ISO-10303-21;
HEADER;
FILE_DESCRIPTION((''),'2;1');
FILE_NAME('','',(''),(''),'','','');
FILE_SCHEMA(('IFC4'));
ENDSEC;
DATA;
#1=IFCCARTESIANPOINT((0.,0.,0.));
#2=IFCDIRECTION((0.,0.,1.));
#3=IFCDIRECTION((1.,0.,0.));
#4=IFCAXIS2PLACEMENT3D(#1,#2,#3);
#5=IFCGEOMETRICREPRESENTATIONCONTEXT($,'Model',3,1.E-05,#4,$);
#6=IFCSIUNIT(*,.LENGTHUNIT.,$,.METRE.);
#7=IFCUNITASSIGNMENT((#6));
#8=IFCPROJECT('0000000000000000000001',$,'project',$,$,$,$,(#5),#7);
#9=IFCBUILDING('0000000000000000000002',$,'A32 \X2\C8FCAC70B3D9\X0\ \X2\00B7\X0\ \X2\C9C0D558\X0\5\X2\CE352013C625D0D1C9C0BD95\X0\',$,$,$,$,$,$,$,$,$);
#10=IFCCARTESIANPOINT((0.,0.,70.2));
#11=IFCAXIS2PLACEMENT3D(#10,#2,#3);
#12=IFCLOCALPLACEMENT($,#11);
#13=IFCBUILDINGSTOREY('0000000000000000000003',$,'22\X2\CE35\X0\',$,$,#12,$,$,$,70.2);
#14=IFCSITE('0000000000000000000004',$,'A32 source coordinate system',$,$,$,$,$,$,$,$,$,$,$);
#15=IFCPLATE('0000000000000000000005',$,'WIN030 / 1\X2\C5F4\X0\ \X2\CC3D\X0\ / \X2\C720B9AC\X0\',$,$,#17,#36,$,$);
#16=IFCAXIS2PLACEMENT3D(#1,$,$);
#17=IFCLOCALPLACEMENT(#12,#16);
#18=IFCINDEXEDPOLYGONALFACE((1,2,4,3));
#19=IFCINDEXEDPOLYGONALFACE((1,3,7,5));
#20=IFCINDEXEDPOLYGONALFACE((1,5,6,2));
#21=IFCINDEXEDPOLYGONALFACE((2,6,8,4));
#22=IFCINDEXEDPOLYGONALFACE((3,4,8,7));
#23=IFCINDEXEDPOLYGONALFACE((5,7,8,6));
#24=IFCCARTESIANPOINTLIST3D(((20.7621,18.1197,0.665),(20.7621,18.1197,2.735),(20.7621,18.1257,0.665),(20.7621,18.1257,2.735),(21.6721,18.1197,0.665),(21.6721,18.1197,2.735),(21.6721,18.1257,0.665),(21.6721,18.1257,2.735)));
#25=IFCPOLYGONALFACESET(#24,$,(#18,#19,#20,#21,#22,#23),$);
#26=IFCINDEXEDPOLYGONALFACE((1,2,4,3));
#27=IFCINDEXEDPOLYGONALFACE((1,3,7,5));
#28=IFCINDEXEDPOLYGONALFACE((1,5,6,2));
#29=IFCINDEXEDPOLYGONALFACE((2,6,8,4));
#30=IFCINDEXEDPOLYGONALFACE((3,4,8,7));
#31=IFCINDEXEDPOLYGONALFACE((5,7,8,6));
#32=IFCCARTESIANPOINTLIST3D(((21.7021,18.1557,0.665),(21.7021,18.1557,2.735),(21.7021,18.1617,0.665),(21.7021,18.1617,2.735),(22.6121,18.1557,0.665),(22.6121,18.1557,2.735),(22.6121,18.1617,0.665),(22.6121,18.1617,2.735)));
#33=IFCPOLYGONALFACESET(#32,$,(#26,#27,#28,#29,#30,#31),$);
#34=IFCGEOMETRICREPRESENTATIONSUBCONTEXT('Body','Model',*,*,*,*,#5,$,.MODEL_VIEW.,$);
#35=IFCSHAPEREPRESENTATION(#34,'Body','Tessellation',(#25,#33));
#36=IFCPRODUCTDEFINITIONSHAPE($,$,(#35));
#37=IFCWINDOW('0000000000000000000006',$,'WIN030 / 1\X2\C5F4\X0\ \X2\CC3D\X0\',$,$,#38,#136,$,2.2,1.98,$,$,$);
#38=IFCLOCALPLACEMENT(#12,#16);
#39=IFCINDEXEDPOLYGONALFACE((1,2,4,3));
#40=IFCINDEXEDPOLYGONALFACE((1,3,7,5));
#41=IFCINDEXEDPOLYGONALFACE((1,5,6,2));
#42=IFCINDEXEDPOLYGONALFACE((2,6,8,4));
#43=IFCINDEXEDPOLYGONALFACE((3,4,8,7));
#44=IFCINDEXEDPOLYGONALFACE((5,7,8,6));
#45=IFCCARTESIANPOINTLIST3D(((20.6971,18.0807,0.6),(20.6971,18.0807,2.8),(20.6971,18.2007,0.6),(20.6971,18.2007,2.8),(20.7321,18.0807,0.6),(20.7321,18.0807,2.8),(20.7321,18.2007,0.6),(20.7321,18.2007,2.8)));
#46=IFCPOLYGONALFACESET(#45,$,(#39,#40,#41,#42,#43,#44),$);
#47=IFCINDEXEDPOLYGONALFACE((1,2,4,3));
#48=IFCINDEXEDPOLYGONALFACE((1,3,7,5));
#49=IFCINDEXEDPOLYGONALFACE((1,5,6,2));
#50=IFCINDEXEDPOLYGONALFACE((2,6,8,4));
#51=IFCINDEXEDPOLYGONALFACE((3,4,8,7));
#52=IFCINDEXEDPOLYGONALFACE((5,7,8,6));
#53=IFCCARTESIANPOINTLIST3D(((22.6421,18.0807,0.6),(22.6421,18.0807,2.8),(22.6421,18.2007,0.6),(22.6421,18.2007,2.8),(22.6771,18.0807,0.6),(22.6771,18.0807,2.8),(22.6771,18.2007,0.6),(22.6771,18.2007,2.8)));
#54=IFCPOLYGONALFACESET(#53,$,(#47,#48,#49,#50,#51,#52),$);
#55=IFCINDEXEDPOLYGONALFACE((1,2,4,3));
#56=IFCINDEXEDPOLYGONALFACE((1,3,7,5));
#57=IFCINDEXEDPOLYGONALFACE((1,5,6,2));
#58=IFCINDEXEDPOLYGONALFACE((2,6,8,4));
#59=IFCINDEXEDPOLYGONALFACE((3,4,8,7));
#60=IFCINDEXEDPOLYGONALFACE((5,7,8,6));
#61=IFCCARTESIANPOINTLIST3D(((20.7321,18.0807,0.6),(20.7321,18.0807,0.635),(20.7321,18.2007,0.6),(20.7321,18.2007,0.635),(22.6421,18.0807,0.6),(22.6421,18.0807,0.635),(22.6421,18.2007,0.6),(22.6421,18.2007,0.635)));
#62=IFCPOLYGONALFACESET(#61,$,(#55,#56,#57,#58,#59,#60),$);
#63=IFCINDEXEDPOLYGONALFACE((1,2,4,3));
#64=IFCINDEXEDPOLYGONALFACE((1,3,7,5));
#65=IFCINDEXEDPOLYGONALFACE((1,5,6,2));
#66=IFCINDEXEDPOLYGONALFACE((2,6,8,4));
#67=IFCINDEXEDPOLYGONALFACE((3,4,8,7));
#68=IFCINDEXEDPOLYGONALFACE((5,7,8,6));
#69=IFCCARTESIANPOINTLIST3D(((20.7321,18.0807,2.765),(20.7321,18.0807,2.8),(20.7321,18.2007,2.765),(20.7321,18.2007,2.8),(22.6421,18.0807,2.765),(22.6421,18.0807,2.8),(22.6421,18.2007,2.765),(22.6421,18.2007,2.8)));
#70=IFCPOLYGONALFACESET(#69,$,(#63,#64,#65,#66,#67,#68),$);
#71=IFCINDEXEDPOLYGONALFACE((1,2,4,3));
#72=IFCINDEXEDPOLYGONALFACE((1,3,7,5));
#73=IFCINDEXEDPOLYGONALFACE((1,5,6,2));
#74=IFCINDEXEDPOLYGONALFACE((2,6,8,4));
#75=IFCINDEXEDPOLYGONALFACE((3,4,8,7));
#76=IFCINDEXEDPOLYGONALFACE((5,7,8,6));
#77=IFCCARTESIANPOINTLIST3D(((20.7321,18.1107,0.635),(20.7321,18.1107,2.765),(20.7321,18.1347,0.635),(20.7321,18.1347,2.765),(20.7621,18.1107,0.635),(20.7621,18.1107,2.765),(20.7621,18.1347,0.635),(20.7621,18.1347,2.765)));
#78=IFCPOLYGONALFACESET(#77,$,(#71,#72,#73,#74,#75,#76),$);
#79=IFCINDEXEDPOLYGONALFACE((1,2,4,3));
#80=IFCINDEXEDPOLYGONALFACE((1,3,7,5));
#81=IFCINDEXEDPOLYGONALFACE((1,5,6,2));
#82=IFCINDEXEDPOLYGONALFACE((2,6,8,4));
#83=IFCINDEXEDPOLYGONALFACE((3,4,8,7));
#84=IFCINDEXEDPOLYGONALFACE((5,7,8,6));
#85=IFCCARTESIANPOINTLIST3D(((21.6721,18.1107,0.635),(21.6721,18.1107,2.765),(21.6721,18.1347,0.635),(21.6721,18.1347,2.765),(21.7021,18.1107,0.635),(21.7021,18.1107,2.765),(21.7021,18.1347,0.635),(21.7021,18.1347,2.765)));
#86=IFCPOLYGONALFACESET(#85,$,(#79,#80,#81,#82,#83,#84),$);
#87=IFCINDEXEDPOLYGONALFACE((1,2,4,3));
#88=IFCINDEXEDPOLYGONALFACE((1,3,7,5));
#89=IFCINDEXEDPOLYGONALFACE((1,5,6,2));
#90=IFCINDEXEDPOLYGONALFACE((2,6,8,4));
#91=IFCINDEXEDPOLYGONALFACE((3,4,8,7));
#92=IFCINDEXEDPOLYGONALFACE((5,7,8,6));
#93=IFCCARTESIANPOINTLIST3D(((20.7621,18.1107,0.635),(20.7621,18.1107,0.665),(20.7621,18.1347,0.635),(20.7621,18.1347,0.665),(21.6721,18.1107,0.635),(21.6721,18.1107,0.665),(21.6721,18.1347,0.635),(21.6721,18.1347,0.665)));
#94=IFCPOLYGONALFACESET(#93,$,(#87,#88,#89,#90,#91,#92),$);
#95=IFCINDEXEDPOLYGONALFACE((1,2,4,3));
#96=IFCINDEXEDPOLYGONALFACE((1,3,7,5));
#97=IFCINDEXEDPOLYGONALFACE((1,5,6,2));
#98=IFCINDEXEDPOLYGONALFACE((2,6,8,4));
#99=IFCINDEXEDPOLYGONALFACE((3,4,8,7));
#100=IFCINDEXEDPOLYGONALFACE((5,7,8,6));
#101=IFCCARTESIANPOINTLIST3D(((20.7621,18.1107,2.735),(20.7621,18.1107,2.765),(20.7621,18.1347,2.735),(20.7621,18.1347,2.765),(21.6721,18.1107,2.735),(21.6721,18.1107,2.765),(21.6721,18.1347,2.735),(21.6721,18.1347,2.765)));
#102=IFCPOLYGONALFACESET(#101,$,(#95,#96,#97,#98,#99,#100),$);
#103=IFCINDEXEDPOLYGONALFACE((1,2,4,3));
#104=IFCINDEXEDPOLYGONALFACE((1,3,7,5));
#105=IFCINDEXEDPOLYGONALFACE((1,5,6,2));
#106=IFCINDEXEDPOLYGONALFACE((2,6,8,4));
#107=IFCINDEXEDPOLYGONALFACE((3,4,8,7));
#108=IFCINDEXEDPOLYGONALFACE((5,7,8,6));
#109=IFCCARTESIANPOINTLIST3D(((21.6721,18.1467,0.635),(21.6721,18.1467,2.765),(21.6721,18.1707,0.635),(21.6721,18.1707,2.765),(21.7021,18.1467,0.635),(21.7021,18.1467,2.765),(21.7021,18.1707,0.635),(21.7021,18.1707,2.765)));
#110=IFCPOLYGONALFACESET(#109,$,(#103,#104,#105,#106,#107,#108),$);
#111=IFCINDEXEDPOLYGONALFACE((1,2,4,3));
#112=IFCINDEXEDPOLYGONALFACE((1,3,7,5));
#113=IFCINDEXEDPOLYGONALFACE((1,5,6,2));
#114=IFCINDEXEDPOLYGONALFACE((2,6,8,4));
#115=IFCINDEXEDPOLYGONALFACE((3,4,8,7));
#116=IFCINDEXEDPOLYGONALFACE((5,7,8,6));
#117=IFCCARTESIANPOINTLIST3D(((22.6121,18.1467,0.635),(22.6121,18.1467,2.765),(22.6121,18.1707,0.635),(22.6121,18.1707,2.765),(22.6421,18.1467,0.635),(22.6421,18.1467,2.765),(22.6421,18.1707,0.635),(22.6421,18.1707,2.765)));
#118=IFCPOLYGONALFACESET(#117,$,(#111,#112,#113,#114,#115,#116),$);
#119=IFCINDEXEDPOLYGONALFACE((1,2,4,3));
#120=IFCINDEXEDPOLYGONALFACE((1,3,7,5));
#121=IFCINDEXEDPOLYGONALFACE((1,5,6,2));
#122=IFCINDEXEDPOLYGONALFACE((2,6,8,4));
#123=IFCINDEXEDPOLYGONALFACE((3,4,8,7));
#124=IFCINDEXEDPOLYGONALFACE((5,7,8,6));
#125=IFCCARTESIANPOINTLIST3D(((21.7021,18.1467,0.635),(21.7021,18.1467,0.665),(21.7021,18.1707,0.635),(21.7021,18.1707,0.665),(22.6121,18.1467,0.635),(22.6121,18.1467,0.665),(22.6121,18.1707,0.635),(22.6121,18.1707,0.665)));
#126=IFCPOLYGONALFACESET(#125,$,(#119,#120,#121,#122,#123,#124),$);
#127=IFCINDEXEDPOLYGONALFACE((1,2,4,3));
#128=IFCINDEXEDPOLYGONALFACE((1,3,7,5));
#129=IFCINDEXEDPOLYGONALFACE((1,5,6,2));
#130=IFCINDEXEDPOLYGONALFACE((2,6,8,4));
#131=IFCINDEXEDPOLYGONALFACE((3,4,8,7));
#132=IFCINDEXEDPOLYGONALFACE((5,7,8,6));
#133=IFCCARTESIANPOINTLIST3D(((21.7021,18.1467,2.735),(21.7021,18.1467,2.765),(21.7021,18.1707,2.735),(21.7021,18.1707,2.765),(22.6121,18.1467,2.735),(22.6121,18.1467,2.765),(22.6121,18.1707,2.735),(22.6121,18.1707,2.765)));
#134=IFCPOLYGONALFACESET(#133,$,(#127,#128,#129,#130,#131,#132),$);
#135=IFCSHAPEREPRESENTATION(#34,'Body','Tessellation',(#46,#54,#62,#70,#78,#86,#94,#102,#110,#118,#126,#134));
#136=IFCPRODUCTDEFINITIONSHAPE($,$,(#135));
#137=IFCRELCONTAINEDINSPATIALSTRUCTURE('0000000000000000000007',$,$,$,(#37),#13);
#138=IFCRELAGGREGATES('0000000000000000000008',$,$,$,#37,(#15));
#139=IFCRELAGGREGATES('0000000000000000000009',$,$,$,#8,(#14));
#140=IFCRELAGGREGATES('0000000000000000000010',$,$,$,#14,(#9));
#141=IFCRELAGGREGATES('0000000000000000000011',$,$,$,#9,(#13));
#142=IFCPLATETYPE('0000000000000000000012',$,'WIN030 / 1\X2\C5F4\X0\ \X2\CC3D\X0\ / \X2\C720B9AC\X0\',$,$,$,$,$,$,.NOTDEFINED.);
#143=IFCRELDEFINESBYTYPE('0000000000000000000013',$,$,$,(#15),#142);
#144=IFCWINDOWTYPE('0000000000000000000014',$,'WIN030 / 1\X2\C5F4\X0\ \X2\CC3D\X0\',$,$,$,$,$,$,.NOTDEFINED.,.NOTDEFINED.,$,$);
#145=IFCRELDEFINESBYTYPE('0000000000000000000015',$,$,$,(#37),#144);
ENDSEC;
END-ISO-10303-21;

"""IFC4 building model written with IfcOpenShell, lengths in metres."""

from ifc_helpers import new_model, si_unit, frame, origin, origin_with_axes, place, context, subcontext, project, spatial, polyline, outline, extrude, source, transform, mapped, type_object, type_shapes, element, aggregate, save


model = new_model("IFC4")

# Units and contexts
model_context = context("Model", 3, precision=1e-05, world=origin_with_axes())
body_context = subcontext(model_context, "Body", "Model", "MODEL_VIEW")
ifc_project = project(units=[si_unit("LENGTHUNIT", "METRE")], contexts=[model_context])

# Plate
storey_placement = place(None, frame((0.0, 0.0, 70.2), z_axis=(0.0, 0.0, 1.0), x_axis=(1.0, 0.0, 0.0)))
plate_type_1 = type_object("IfcPlateType", Name="WIN030 / 1열 창 / 유리", PredefinedType="NOTDEFINED")
shared_shape_1 = source(origin(), body_context, "Body", "SweptSolid", [
    extrude(outline(polyline([(20.7621, 18.1197), (20.7621, 18.1257), (21.6721, 18.1257), (21.6721, 18.1197), (20.7621, 18.1197)])), frame((0.0, 0.0, 0.665)), (0.0, 0.0, 1.0), 2.07),
    extrude(outline(polyline([(21.7021, 18.1557), (21.7021, 18.1617), (22.6121, 18.1617), (22.6121, 18.1557), (21.7021, 18.1557)])), frame((0.0, 0.0, 0.665)), (0.0, 0.0, 1.0), 2.07),
])
type_shapes(plate_type_1, [shared_shape_1])
window_1_placement = place(storey_placement, origin_with_axes())
plate_1_placement = place(window_1_placement, origin_with_axes())
plate_1 = element("IfcPlate", 1, at=plate_1_placement, type_object=plate_type_1, Name="WIN030 / 1열 창 / 유리", context=body_context, shape_type="MappedRepresentation", body=[
    mapped(shared_shape_1, transform((0.0, 0.0, 0.0), scale=1.0)),
])

# Site, building, storey
site = spatial("IfcSite", under=ifc_project, Name="A32 source coordinate system")
building = spatial("IfcBuilding", under=site, Name="A32 주거동 · 지하5층–옥탑지붕")
storey = spatial("IfcBuildingStorey", under=building, at=storey_placement, Name="22층", Elevation=70.2)

# Window
window_type_1 = type_object("IfcWindowType", Name="WIN030 / 1열 창", PartitioningType="NOTDEFINED", PredefinedType="NOTDEFINED")
shared_shape_2 = source(origin(), body_context, "Body", "SweptSolid", [
    extrude(outline(polyline([(20.6971, 18.0807), (20.6971, 18.2007), (20.7321, 18.2007), (20.7321, 18.0807), (20.6971, 18.0807)])), frame((0.0, 0.0, 0.6)), (0.0, 0.0, 1.0), 2.2),
    extrude(outline(polyline([(22.6421, 18.0807), (22.6421, 18.2007), (22.6771, 18.2007), (22.6771, 18.0807), (22.6421, 18.0807)])), frame((0.0, 0.0, 0.6)), (0.0, 0.0, 1.0), 2.2),
    extrude(outline(polyline([(20.7321, 18.0807), (20.7321, 18.2007), (22.6421, 18.2007), (22.6421, 18.0807), (20.7321, 18.0807)])), frame((0.0, 0.0, 0.6)), (0.0, 0.0, 1.0), 0.035),
    extrude(outline(polyline([(20.7321, 18.0807), (20.7321, 18.2007), (22.6421, 18.2007), (22.6421, 18.0807), (20.7321, 18.0807)])), frame((0.0, 0.0, 2.765)), (0.0, 0.0, 1.0), 0.035),
    extrude(outline(polyline([(20.7321, 18.1107), (20.7321, 18.1347), (20.7621, 18.1347), (20.7621, 18.1107), (20.7321, 18.1107)])), frame((0.0, 0.0, 0.635)), (0.0, 0.0, 1.0), 2.13),
    extrude(outline(polyline([(21.6721, 18.1107), (21.6721, 18.1347), (21.7021, 18.1347), (21.7021, 18.1107), (21.6721, 18.1107)])), frame((0.0, 0.0, 0.635)), (0.0, 0.0, 1.0), 2.13),
    extrude(outline(polyline([(20.7621, 18.1107), (20.7621, 18.1347), (21.6721, 18.1347), (21.6721, 18.1107), (20.7621, 18.1107)])), frame((0.0, 0.0, 0.635)), (0.0, 0.0, 1.0), 0.03),
    extrude(outline(polyline([(20.7621, 18.1107), (20.7621, 18.1347), (21.6721, 18.1347), (21.6721, 18.1107), (20.7621, 18.1107)])), frame((0.0, 0.0, 2.735)), (0.0, 0.0, 1.0), 0.03),
    extrude(outline(polyline([(21.6721, 18.1467), (21.6721, 18.1707), (21.7021, 18.1707), (21.7021, 18.1467), (21.6721, 18.1467)])), frame((0.0, 0.0, 0.635)), (0.0, 0.0, 1.0), 2.13),
    extrude(outline(polyline([(22.6121, 18.1467), (22.6121, 18.1707), (22.6421, 18.1707), (22.6421, 18.1467), (22.6121, 18.1467)])), frame((0.0, 0.0, 0.635)), (0.0, 0.0, 1.0), 2.13),
    extrude(outline(polyline([(21.7021, 18.1467), (21.7021, 18.1707), (22.6121, 18.1707), (22.6121, 18.1467), (21.7021, 18.1467)])), frame((0.0, 0.0, 0.635)), (0.0, 0.0, 1.0), 0.03),
    extrude(outline(polyline([(21.7021, 18.1467), (21.7021, 18.1707), (22.6121, 18.1707), (22.6121, 18.1467), (21.7021, 18.1467)])), frame((0.0, 0.0, 2.735)), (0.0, 0.0, 1.0), 0.03),
])
type_shapes(window_type_1, [shared_shape_2])
window_1 = element("IfcWindow", 2, at=window_1_placement, inside=storey, type_object=window_type_1, Name="WIN030 / 1열 창", OverallHeight=2.2, OverallWidth=1.98, context=body_context, shape_type="MappedRepresentation", body=[
    mapped(shared_shape_2, transform((0.0, 0.0, 0.0), scale=1.0)),
])
aggregate(window_1, [plate_1])

save(model, "model.ifc")
